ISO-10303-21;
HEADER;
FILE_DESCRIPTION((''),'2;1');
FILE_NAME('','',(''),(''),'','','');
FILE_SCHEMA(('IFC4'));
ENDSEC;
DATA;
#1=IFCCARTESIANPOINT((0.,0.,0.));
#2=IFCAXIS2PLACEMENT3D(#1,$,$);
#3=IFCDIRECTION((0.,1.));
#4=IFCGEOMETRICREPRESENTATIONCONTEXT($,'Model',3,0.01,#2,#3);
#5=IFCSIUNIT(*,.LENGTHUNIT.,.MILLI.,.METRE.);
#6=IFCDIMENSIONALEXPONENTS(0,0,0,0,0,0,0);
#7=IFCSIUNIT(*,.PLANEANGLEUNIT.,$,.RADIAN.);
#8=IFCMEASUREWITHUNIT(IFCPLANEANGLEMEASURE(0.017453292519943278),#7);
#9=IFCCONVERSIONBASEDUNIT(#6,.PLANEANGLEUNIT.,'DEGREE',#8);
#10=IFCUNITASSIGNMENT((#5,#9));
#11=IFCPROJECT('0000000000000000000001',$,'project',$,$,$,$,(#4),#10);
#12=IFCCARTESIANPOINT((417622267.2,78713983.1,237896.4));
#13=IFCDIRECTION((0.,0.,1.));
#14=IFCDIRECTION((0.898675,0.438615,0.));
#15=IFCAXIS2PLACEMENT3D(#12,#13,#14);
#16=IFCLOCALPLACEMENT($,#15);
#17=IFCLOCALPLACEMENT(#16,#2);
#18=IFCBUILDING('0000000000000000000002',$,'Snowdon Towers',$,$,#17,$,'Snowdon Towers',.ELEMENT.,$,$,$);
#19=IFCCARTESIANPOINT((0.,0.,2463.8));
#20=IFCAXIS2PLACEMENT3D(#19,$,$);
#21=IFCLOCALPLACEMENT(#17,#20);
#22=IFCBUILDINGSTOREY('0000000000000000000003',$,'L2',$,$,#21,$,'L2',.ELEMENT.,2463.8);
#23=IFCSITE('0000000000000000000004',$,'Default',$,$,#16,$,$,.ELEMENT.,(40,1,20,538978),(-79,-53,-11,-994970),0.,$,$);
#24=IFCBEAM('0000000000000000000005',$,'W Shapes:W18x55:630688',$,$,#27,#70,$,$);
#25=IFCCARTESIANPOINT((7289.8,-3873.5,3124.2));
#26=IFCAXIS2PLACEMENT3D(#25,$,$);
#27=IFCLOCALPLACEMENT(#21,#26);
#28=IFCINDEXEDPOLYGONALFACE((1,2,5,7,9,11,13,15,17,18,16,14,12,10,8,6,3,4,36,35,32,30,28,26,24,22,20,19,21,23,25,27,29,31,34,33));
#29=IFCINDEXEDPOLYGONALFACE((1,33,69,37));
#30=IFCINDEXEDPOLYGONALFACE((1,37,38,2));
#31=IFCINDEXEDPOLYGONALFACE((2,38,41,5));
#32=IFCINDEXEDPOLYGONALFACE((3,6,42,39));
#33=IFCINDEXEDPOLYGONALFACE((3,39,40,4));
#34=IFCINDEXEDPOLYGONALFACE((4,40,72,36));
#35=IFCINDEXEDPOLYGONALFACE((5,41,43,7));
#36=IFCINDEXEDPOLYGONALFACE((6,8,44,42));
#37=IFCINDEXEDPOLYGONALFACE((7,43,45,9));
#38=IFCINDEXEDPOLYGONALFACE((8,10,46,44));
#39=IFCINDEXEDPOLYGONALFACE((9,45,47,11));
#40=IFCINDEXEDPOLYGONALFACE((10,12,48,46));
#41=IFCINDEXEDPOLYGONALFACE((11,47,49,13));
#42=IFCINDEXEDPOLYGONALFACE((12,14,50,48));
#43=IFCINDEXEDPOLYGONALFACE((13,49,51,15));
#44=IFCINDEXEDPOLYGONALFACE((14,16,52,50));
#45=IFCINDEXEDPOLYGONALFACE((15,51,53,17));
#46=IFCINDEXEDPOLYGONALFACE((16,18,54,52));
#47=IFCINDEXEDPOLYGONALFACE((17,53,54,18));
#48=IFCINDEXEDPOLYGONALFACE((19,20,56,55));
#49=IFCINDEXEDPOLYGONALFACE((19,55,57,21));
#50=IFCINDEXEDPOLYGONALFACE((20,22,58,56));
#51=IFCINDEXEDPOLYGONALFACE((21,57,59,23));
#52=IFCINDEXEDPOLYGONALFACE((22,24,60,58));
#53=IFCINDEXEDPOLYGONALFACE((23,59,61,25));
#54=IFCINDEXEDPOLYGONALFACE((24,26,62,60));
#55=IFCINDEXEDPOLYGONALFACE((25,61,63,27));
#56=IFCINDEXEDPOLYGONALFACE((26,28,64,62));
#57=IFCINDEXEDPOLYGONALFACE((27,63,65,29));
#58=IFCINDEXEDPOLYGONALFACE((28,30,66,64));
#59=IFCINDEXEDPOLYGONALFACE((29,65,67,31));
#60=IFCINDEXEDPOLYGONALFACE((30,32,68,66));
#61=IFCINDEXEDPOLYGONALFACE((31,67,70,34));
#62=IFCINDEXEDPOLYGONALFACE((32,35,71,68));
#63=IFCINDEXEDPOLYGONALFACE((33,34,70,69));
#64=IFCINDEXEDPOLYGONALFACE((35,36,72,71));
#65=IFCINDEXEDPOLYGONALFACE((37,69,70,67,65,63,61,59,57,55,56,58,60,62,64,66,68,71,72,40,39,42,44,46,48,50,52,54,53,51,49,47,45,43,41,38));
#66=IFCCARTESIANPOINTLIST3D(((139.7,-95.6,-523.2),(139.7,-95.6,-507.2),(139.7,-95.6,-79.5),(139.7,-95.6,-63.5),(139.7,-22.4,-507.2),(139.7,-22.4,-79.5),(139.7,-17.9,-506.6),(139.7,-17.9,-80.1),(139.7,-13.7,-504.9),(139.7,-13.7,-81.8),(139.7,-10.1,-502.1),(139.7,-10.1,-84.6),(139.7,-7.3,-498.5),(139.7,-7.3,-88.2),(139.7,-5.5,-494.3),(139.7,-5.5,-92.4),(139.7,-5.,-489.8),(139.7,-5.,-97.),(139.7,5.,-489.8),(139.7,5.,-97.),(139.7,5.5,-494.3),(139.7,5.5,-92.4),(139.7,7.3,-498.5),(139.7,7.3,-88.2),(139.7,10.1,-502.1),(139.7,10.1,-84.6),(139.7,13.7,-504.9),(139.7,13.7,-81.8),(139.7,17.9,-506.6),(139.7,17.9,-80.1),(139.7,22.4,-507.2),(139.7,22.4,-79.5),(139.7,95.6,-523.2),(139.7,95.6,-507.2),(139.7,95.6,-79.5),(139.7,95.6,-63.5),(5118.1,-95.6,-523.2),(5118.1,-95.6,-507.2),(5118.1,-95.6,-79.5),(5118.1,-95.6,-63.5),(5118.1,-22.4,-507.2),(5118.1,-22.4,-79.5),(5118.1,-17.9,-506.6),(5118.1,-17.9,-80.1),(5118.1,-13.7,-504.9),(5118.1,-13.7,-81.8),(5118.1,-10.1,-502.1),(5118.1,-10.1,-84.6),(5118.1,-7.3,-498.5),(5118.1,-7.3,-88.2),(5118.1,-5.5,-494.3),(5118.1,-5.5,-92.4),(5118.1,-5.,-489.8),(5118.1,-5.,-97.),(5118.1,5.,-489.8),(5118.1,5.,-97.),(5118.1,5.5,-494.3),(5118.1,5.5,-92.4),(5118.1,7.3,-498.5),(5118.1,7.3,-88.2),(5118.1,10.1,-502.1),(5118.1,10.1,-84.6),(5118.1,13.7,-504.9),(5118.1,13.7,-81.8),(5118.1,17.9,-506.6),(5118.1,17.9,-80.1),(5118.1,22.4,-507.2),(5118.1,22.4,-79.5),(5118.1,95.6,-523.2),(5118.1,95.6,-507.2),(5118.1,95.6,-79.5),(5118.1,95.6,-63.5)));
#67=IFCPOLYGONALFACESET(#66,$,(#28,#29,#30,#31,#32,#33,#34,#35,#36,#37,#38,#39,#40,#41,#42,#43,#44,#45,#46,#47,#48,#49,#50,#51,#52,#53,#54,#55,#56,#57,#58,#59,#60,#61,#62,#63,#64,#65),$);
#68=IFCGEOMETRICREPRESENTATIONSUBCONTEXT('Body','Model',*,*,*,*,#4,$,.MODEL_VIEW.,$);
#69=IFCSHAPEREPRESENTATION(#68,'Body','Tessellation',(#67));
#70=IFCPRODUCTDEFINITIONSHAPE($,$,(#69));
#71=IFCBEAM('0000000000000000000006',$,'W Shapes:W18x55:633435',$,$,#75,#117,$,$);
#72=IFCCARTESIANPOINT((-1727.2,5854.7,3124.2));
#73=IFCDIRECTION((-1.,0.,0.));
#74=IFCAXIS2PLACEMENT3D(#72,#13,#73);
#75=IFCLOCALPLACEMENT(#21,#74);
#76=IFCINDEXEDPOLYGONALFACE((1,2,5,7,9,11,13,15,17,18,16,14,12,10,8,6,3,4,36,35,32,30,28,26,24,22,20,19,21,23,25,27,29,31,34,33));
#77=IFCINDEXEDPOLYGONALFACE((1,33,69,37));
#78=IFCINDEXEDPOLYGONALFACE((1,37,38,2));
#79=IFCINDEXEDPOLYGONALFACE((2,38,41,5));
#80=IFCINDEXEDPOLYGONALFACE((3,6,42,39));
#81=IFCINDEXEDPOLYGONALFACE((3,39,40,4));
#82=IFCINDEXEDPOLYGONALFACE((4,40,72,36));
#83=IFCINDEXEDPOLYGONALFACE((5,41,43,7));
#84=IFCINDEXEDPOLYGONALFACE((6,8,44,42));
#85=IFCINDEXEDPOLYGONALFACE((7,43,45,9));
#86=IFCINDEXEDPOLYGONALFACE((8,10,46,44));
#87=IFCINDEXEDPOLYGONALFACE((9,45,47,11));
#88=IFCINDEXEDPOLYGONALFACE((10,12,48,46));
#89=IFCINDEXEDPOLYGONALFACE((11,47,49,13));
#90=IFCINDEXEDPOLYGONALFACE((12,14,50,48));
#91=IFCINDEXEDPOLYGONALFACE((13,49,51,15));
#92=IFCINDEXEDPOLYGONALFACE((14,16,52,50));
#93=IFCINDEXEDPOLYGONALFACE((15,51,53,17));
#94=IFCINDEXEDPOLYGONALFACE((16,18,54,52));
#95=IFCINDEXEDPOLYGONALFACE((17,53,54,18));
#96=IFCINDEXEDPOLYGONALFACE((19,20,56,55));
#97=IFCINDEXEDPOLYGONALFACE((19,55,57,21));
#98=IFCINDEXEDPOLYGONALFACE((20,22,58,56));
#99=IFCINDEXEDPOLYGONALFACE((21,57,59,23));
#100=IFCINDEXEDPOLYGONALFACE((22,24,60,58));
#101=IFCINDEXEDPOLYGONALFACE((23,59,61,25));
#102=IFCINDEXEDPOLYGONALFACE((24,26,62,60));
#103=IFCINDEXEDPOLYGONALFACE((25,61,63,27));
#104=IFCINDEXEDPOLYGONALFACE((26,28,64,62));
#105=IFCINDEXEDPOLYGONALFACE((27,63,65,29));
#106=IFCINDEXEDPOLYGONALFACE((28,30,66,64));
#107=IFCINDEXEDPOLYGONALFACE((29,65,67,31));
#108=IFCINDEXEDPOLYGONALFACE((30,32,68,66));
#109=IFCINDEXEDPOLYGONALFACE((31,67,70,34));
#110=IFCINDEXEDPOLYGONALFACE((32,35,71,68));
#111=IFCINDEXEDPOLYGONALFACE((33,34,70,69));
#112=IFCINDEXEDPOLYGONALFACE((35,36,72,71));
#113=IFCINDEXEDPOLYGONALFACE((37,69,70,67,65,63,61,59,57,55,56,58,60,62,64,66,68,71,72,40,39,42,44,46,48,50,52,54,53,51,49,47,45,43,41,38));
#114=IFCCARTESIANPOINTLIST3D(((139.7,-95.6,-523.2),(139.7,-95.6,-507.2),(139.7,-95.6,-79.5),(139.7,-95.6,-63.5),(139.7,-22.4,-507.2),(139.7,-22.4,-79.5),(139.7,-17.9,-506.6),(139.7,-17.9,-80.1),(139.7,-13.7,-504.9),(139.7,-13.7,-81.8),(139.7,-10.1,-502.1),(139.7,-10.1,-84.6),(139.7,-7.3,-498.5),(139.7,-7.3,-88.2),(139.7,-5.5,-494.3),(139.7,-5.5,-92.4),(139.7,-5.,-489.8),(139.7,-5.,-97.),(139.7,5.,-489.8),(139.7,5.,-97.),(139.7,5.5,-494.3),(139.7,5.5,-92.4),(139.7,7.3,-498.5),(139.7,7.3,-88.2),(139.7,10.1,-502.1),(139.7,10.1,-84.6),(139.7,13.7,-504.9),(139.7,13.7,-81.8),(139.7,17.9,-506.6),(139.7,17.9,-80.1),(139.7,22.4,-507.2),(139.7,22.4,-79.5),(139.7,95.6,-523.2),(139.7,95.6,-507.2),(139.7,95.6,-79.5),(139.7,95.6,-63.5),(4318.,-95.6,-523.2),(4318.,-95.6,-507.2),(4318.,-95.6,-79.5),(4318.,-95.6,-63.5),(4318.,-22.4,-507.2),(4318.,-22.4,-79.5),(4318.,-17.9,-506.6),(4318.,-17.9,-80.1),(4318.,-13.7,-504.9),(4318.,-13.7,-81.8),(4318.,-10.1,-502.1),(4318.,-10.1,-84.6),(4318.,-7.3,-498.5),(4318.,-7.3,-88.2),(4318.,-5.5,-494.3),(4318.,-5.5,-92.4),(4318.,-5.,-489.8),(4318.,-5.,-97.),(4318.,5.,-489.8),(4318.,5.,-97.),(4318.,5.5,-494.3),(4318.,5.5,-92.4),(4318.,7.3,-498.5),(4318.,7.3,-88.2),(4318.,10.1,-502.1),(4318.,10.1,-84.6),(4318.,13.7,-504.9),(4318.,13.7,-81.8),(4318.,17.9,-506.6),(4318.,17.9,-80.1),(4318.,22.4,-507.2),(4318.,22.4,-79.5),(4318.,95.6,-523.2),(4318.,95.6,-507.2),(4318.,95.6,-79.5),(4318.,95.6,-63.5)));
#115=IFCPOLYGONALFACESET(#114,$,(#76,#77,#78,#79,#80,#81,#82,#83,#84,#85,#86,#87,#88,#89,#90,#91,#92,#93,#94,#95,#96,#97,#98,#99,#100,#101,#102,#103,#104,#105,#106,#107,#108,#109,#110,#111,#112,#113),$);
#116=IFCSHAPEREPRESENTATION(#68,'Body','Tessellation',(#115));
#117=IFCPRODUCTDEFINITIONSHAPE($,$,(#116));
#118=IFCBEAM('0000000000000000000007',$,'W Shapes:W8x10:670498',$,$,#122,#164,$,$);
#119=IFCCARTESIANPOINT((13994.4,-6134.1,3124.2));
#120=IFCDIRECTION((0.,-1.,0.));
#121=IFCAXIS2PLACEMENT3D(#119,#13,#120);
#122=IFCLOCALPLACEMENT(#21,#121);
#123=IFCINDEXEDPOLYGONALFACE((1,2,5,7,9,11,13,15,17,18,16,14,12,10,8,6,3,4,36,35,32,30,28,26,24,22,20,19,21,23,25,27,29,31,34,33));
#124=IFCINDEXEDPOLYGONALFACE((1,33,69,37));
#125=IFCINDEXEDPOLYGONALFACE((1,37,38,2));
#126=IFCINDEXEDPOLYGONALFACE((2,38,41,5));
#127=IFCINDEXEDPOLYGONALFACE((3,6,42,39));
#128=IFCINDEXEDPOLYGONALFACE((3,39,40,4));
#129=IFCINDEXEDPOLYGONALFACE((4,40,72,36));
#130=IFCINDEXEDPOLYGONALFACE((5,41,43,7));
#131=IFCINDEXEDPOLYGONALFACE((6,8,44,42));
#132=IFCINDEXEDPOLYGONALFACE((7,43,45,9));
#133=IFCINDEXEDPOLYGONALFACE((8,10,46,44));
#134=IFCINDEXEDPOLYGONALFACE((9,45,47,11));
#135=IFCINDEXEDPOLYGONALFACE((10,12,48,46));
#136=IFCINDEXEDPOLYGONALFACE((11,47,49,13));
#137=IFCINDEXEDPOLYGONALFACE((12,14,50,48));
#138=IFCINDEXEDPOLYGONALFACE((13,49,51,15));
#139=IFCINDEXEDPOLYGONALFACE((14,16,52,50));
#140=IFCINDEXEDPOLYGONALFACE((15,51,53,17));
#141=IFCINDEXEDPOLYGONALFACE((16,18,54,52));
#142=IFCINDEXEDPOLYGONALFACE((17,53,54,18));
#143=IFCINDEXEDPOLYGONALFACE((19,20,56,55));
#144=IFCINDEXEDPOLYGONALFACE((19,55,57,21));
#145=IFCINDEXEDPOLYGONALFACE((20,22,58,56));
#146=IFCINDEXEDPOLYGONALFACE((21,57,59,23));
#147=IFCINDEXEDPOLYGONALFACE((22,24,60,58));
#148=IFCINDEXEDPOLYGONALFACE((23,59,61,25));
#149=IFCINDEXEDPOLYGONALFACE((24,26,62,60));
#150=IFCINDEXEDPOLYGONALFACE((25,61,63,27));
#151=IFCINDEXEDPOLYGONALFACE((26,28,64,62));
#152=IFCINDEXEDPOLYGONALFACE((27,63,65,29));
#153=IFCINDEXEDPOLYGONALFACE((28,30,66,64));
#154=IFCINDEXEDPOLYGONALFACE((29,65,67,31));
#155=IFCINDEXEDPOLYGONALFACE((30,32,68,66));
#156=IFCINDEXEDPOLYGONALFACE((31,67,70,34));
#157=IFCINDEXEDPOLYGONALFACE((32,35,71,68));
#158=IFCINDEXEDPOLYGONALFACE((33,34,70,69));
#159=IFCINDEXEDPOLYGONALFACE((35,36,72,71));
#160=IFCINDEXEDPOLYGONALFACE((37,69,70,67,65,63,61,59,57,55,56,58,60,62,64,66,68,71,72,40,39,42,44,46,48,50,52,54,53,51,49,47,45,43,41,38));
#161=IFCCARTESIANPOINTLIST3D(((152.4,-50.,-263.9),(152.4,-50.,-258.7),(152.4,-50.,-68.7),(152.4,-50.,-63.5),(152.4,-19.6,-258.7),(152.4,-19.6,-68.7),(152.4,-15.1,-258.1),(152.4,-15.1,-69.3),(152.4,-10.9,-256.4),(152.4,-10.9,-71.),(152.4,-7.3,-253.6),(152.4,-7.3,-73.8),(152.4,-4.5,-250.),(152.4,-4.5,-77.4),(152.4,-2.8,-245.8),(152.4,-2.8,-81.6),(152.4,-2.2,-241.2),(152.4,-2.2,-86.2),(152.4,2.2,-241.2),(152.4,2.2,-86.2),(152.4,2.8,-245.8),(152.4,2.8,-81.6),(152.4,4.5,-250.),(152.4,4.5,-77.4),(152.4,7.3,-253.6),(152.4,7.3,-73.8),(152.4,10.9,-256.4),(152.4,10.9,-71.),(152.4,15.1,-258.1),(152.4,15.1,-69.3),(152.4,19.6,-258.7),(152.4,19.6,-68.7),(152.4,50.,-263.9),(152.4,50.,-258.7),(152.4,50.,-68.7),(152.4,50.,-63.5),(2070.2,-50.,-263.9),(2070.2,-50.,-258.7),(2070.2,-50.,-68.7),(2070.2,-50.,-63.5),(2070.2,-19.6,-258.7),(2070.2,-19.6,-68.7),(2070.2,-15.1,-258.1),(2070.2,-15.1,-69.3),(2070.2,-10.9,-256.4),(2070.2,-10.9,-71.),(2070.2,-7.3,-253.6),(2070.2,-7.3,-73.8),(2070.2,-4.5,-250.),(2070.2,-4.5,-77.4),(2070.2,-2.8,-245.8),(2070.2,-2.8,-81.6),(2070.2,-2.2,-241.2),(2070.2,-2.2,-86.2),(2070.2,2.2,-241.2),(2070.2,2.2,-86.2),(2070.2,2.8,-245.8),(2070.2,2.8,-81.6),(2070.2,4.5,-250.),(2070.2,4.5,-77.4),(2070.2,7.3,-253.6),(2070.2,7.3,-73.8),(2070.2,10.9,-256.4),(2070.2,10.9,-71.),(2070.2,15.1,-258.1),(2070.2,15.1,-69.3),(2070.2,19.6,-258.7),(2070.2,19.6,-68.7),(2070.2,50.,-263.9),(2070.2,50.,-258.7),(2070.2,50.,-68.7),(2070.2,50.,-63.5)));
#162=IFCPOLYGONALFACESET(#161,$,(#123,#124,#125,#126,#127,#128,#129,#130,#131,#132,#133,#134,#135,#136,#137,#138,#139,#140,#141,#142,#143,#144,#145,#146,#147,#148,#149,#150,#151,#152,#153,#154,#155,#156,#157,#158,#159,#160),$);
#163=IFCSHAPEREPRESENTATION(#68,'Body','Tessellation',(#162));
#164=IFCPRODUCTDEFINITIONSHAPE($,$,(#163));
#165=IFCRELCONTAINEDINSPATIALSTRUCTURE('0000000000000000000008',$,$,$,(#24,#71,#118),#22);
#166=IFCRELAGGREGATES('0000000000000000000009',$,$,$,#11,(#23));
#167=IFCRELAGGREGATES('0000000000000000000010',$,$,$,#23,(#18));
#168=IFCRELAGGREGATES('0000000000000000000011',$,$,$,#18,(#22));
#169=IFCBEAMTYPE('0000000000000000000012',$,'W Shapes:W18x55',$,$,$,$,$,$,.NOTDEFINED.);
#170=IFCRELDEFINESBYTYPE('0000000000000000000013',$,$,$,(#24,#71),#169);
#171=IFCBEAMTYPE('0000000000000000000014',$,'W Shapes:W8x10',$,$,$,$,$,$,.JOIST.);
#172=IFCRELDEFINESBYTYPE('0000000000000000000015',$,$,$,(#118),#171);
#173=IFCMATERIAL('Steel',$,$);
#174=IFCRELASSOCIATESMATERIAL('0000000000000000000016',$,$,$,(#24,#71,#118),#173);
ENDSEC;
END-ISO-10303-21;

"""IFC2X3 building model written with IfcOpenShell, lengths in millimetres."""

from ifc_helpers import new_model, entity, si_unit, converted_unit, direction, frame, frame_2d, origin, place, context, subcontext, project, spatial, i_section, extrude, material, type_object, element, save


model = new_model("IFC2X3")

# Units and contexts
model_context = context("Model", 3, precision=0.01, world=origin(), true_north=direction((0.0, 1.0)))
body_context = subcontext(model_context, "Body", "Model", "MODEL_VIEW")
ifc_project = project(units=[si_unit("LENGTHUNIT", "METRE", prefix="MILLI"), converted_unit("PLANEANGLEUNIT", "DEGREE", entity("IfcPlaneAngleMeasure", 0.017453292519943278), si_unit("PLANEANGLEUNIT", "RADIAN"), dimensions=[0, 0, 0, 0, 0, 0, 0])], contexts=[model_context])

# Site, building, storey
site_placement = place(None, frame((417622267.2, 78713983.1, 237896.4), z_axis=(0.0, 0.0, 1.0), x_axis=(0.898675, 0.438615, 0.0)))
site = spatial("IfcSite", under=ifc_project, at=site_placement, Name="Default", CompositionType="ELEMENT", RefLatitude=(40, 1, 20, 538978), RefLongitude=(-79, -53, -11, -994970), RefElevation=0.0)
building_placement = place(site_placement, origin())
building = spatial("IfcBuilding", under=site, at=building_placement, Name="Snowdon Towers", LongName="Snowdon Towers", CompositionType="ELEMENT")
storey_placement = place(building_placement, frame((0.0, 0.0, 2463.8)))
storey = spatial("IfcBuildingStorey", under=building, at=storey_placement, Name="L2", LongName="L2", CompositionType="ELEMENT", Elevation=2463.8)

# Shared definitions
ifc_material_1 = material(Name="Steel")

# Beams
beam_type_1 = type_object("IfcBeamType", Name="W Shapes:W18x55", PredefinedType="NOTDEFINED")
beam_1_placement = place(storey_placement, frame((7289.8, -3873.5, 3124.2)))
element("IfcBeam", 1, at=beam_1_placement, inside=storey, type_object=beam_type_1, material=ifc_material_1, Name="W Shapes:W18x55:630688", context=body_context, shape_type="SweptSolid", body=[
    extrude(i_section(OverallWidth=191.3, OverallDepth=459.7, WebThickness=9.9, FlangeThickness=16.0, FilletRadius=17.5, at=frame_2d((0.0, 0.0), x_axis=(0.0, 1.0))), frame((139.7, 0.0, -293.4), z_axis=(1.0, 0.0, 0.0), x_axis=(0.0, 0.0, -1.0)), (0.0, 0.0, 1.0), 4978.4),
])
beam_2_placement = place(storey_placement, frame((-1727.2, 5854.7, 3124.2), z_axis=(0.0, 0.0, 1.0), x_axis=(-1.0, 0.0, 0.0)))
element("IfcBeam", 2, at=beam_2_placement, inside=storey, type_object=beam_type_1, material=ifc_material_1, Name="W Shapes:W18x55:633435", context=body_context, shape_type="SweptSolid", body=[
    extrude(i_section(OverallWidth=191.3, OverallDepth=459.7, WebThickness=9.9, FlangeThickness=16.0, FilletRadius=17.5, at=frame_2d((0.0, 0.0), x_axis=(0.0, 1.0))), frame((139.7, 0.0, -293.4), z_axis=(1.0, 0.0, 0.0), x_axis=(0.0, 0.0, -1.0)), (0.0, 0.0, 1.0), 4178.3),
])
beam_type_2 = type_object("IfcBeamType", Name="W Shapes:W8x10", PredefinedType="JOIST")
beam_3_placement = place(storey_placement, frame((13994.4, -6134.1, 3124.2), z_axis=(0.0, 0.0, 1.0), x_axis=(0.0, -1.0, 0.0)))
element("IfcBeam", 3, at=beam_3_placement, inside=storey, type_object=beam_type_2, material=ifc_material_1, Name="W Shapes:W8x10:670498", context=body_context, shape_type="SweptSolid", body=[
    extrude(i_section(OverallWidth=100.1, OverallDepth=200.4, WebThickness=4.3, FlangeThickness=5.2, FilletRadius=17.5, at=frame_2d((0.0, 0.0), x_axis=(0.0, 1.0))), frame((152.4, 0.0, -163.7), z_axis=(1.0, 0.0, 0.0), x_axis=(0.0, 0.0, -1.0)), (0.0, 0.0, 1.0), 1917.8),
])

save(model, "model.ifc")
